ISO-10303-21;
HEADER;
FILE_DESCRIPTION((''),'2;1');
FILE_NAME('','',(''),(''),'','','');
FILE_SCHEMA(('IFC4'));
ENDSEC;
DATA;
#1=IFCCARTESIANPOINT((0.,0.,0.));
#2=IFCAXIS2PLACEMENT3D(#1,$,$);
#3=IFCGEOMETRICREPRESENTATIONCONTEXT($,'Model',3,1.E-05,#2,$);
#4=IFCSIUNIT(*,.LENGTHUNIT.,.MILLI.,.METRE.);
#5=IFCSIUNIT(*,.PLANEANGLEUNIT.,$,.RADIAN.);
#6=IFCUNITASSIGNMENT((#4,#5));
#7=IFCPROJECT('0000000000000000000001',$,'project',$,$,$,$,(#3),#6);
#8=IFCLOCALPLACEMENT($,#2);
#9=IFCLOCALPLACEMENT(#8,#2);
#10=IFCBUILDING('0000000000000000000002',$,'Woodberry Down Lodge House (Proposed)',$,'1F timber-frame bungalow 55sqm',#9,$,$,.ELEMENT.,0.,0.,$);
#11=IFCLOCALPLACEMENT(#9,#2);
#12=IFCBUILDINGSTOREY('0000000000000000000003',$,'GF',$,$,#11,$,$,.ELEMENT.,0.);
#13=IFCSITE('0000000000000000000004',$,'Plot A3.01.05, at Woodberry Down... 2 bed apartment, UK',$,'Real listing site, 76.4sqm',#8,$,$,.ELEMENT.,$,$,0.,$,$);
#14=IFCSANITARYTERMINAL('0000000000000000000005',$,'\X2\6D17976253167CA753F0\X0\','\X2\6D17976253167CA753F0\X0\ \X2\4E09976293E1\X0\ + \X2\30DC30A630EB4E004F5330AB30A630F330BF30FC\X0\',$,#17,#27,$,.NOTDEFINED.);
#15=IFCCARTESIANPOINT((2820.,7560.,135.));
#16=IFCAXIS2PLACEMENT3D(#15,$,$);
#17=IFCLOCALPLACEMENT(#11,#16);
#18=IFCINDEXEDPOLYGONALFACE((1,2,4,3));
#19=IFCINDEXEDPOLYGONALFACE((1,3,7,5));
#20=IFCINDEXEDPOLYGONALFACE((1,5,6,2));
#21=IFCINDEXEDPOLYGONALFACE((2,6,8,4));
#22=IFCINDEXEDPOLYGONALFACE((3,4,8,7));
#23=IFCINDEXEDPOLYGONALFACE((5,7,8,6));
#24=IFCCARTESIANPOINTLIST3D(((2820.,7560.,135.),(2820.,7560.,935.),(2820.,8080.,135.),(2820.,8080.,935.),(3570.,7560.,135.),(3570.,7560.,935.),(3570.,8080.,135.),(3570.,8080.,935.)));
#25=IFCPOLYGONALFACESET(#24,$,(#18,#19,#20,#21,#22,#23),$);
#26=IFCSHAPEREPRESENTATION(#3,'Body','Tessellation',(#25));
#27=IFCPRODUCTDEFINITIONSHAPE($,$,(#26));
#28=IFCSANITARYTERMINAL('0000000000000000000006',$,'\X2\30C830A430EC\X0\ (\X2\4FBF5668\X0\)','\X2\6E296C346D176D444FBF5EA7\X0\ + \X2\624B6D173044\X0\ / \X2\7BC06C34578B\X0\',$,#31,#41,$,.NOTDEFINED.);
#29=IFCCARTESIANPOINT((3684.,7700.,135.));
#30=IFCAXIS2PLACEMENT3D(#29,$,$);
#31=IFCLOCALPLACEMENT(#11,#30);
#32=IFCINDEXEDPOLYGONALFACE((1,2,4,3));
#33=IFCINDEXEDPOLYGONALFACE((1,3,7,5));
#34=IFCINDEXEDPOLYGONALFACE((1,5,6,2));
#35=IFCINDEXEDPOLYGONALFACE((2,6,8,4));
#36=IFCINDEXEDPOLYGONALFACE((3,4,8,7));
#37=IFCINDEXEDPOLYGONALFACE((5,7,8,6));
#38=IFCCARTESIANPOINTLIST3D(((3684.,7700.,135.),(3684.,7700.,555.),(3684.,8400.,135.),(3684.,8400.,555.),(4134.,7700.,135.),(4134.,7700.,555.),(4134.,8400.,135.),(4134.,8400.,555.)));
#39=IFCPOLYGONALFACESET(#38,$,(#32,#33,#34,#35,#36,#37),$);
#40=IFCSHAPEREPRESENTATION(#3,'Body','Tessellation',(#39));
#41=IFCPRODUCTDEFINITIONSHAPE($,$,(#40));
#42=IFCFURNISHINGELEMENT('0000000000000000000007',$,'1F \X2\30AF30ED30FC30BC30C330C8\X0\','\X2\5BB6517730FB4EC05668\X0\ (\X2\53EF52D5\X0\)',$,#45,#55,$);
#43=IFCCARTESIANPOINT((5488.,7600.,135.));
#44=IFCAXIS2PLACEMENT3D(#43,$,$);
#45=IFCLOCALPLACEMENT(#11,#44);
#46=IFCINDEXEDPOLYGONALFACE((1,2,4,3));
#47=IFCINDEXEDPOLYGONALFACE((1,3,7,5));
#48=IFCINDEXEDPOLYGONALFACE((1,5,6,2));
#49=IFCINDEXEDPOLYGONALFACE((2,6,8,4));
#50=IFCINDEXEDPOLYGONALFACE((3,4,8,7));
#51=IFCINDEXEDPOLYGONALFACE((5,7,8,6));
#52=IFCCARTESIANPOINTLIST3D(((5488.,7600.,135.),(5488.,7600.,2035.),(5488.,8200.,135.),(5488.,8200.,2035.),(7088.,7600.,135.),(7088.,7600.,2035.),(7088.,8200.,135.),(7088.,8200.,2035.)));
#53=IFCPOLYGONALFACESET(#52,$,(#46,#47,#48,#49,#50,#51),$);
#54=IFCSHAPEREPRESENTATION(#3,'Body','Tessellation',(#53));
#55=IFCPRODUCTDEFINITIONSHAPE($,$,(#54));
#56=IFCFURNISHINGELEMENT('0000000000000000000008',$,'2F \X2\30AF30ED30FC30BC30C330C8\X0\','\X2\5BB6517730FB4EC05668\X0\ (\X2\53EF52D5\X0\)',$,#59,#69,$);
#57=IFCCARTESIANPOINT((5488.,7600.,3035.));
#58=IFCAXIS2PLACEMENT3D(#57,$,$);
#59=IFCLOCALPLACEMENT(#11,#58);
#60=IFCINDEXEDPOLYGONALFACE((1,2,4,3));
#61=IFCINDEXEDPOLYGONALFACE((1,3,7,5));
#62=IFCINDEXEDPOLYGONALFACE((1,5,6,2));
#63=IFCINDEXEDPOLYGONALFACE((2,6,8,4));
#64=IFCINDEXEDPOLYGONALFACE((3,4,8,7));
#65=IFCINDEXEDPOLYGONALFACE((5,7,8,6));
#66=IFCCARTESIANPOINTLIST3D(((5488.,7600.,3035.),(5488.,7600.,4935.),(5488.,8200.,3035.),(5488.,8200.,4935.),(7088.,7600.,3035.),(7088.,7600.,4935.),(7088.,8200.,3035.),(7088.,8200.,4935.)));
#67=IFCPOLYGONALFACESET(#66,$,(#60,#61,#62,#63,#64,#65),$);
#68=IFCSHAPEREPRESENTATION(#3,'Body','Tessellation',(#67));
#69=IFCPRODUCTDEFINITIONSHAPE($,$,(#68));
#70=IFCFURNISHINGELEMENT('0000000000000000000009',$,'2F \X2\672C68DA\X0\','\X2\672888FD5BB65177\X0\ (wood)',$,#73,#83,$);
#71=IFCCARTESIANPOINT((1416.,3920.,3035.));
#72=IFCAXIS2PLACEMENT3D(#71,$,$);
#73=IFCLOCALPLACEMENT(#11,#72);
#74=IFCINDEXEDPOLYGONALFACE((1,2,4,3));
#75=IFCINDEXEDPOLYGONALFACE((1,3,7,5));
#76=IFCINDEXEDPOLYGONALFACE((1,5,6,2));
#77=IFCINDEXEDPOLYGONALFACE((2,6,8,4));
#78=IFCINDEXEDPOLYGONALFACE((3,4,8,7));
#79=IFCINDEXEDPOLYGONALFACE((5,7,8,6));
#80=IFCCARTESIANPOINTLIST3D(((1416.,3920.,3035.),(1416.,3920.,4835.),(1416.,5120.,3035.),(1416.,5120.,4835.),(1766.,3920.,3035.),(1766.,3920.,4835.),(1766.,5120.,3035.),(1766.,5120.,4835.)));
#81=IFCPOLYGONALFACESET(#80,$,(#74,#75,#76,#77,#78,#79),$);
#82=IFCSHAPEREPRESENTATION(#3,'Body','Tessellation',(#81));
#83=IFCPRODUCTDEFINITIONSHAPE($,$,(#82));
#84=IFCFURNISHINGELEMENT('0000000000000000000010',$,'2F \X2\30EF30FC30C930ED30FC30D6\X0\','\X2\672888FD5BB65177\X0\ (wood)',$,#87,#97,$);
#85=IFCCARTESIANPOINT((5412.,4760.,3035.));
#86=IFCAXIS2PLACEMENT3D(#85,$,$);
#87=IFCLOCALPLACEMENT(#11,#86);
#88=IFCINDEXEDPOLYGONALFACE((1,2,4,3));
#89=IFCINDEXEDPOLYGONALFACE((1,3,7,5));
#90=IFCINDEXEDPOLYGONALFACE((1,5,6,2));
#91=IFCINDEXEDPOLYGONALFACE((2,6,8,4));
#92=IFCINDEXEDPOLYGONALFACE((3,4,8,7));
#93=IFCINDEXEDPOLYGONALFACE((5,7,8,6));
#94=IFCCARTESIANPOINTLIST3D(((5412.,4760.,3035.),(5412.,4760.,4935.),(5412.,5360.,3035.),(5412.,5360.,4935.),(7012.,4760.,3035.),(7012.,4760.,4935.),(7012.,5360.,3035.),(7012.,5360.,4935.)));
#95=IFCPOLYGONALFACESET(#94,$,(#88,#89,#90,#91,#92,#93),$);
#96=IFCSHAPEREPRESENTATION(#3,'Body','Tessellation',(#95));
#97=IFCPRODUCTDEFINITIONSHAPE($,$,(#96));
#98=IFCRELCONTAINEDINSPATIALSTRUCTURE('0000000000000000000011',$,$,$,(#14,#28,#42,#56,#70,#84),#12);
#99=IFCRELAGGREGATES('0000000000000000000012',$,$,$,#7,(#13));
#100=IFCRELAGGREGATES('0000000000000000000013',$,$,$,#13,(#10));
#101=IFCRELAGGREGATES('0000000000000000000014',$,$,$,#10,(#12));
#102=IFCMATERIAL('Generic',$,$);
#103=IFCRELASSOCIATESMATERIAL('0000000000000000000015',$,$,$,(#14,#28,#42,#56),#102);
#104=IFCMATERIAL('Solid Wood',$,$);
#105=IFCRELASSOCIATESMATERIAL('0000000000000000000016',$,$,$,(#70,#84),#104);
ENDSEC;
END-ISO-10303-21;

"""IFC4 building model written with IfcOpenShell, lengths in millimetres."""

from ifc_helpers import new_model, si_unit, frame, frame_2d, origin, place, context, project, spatial, rectangle, extrude, material, element, save


model = new_model("IFC4")

# Units and contexts
model_context = context("Model", 3, precision=1e-05, world=origin())
ifc_project = project(units=[si_unit("LENGTHUNIT", "METRE", prefix="MILLI"), si_unit("PLANEANGLEUNIT", "RADIAN")], contexts=[model_context])

# Site, building, storey
site_placement = place(None, origin())
site = spatial("IfcSite", under=ifc_project, at=site_placement, Name="Plot A3.01.05, at Woodberry Down... 2 bed apartment, UK", ObjectType="Real listing site, 76.4sqm", CompositionType="ELEMENT", RefElevation=0.0)
building_placement = place(site_placement, origin())
building = spatial("IfcBuilding", under=site, at=building_placement, Name="Woodberry Down Lodge House (Proposed)", ObjectType="1F timber-frame bungalow 55sqm", CompositionType="ELEMENT", ElevationOfRefHeight=0.0, ElevationOfTerrain=0.0)
storey_placement = place(building_placement, origin())
storey = spatial("IfcBuildingStorey", under=building, at=storey_placement, Name="GF", CompositionType="ELEMENT", Elevation=0.0)

# Shared definitions
ifc_material_1 = material(Name="Solid Wood")

# Shared definitions
ifc_material_2 = material(Name="Generic")

# Sanitary terminals
sanitary_terminal_1_placement = place(storey_placement, frame((2820.0, 7560.0, 135.0)))
element("IfcSanitaryTerminal", 1, at=sanitary_terminal_1_placement, inside=storey, material=ifc_material_2, Name="洗面化粧台", Description="洗面化粧台 三面鏡 + ボウル一体カウンター", PredefinedType="NOTDEFINED", context=model_context, shape_type="SweptSolid", body=[
    extrude(rectangle(XDim=750.0, YDim=520.0, at=frame_2d((375.0, 260.0))), frame((2820.0, 7560.0, 135.0)), (0.0, 0.0, 1.0), 800.0),
])
sanitary_terminal_2_placement = place(storey_placement, frame((3684.0, 7700.0, 135.0)))
element("IfcSanitaryTerminal", 2, at=sanitary_terminal_2_placement, inside=storey, material=ifc_material_2, Name="トイレ (便器)", Description="温水洗浄便座 + 手洗い / 節水型", PredefinedType="NOTDEFINED", context=model_context, shape_type="SweptSolid", body=[
    extrude(rectangle(XDim=450.0, YDim=700.0, at=frame_2d((225.0, 350.0))), frame((3684.0, 7700.0, 135.0)), (0.0, 0.0, 1.0), 420.0),
])

# Furnishing elements
furnishing_1_placement = place(storey_placement, frame((5488.0, 7600.0, 135.0)))
element("IfcFurnishingElement", 3, at=furnishing_1_placement, inside=storey, material=ifc_material_2, Name="1F クローゼット", Description="家具・什器 (可動)", context=model_context, shape_type="SweptSolid", body=[
    extrude(rectangle(XDim=1600.0, YDim=600.0, at=frame_2d((800.0, 300.0))), frame((5488.0, 7600.0, 135.0)), (0.0, 0.0, 1.0), 1900.0),
])
furnishing_2_placement = place(storey_placement, frame((5488.0, 7600.0, 3035.0)))
element("IfcFurnishingElement", 4, at=furnishing_2_placement, inside=storey, material=ifc_material_2, Name="2F クローゼット", Description="家具・什器 (可動)", context=model_context, shape_type="SweptSolid", body=[
    extrude(rectangle(XDim=1600.0, YDim=600.0, at=frame_2d((800.0, 300.0))), frame((5488.0, 7600.0, 3035.0)), (0.0, 0.0, 1.0), 1900.0),
])
furnishing_3_placement = place(storey_placement, frame((1416.0, 3920.0, 3035.0)))
element("IfcFurnishingElement", 5, at=furnishing_3_placement, inside=storey, material=ifc_material_1, Name="2F 本棚", Description="木製家具 (wood)", context=model_context, shape_type="SweptSolid", body=[
    extrude(rectangle(XDim=350.0, YDim=1200.0, at=frame_2d((175.0, 600.0))), frame((1416.0, 3920.0, 3035.0)), (0.0, 0.0, 1.0), 1800.0),
])
furnishing_4_placement = place(storey_placement, frame((5412.0, 4760.0, 3035.0)))
element("IfcFurnishingElement", 6, at=furnishing_4_placement, inside=storey, material=ifc_material_1, Name="2F ワードローブ", Description="木製家具 (wood)", context=model_context, shape_type="SweptSolid", body=[
    extrude(rectangle(XDim=1600.0, YDim=600.0, at=frame_2d((800.0, 300.0))), frame((5412.0, 4760.0, 3035.0)), (0.0, 0.0, 1.0), 1900.0),
])

save(model, "model.ifc")
